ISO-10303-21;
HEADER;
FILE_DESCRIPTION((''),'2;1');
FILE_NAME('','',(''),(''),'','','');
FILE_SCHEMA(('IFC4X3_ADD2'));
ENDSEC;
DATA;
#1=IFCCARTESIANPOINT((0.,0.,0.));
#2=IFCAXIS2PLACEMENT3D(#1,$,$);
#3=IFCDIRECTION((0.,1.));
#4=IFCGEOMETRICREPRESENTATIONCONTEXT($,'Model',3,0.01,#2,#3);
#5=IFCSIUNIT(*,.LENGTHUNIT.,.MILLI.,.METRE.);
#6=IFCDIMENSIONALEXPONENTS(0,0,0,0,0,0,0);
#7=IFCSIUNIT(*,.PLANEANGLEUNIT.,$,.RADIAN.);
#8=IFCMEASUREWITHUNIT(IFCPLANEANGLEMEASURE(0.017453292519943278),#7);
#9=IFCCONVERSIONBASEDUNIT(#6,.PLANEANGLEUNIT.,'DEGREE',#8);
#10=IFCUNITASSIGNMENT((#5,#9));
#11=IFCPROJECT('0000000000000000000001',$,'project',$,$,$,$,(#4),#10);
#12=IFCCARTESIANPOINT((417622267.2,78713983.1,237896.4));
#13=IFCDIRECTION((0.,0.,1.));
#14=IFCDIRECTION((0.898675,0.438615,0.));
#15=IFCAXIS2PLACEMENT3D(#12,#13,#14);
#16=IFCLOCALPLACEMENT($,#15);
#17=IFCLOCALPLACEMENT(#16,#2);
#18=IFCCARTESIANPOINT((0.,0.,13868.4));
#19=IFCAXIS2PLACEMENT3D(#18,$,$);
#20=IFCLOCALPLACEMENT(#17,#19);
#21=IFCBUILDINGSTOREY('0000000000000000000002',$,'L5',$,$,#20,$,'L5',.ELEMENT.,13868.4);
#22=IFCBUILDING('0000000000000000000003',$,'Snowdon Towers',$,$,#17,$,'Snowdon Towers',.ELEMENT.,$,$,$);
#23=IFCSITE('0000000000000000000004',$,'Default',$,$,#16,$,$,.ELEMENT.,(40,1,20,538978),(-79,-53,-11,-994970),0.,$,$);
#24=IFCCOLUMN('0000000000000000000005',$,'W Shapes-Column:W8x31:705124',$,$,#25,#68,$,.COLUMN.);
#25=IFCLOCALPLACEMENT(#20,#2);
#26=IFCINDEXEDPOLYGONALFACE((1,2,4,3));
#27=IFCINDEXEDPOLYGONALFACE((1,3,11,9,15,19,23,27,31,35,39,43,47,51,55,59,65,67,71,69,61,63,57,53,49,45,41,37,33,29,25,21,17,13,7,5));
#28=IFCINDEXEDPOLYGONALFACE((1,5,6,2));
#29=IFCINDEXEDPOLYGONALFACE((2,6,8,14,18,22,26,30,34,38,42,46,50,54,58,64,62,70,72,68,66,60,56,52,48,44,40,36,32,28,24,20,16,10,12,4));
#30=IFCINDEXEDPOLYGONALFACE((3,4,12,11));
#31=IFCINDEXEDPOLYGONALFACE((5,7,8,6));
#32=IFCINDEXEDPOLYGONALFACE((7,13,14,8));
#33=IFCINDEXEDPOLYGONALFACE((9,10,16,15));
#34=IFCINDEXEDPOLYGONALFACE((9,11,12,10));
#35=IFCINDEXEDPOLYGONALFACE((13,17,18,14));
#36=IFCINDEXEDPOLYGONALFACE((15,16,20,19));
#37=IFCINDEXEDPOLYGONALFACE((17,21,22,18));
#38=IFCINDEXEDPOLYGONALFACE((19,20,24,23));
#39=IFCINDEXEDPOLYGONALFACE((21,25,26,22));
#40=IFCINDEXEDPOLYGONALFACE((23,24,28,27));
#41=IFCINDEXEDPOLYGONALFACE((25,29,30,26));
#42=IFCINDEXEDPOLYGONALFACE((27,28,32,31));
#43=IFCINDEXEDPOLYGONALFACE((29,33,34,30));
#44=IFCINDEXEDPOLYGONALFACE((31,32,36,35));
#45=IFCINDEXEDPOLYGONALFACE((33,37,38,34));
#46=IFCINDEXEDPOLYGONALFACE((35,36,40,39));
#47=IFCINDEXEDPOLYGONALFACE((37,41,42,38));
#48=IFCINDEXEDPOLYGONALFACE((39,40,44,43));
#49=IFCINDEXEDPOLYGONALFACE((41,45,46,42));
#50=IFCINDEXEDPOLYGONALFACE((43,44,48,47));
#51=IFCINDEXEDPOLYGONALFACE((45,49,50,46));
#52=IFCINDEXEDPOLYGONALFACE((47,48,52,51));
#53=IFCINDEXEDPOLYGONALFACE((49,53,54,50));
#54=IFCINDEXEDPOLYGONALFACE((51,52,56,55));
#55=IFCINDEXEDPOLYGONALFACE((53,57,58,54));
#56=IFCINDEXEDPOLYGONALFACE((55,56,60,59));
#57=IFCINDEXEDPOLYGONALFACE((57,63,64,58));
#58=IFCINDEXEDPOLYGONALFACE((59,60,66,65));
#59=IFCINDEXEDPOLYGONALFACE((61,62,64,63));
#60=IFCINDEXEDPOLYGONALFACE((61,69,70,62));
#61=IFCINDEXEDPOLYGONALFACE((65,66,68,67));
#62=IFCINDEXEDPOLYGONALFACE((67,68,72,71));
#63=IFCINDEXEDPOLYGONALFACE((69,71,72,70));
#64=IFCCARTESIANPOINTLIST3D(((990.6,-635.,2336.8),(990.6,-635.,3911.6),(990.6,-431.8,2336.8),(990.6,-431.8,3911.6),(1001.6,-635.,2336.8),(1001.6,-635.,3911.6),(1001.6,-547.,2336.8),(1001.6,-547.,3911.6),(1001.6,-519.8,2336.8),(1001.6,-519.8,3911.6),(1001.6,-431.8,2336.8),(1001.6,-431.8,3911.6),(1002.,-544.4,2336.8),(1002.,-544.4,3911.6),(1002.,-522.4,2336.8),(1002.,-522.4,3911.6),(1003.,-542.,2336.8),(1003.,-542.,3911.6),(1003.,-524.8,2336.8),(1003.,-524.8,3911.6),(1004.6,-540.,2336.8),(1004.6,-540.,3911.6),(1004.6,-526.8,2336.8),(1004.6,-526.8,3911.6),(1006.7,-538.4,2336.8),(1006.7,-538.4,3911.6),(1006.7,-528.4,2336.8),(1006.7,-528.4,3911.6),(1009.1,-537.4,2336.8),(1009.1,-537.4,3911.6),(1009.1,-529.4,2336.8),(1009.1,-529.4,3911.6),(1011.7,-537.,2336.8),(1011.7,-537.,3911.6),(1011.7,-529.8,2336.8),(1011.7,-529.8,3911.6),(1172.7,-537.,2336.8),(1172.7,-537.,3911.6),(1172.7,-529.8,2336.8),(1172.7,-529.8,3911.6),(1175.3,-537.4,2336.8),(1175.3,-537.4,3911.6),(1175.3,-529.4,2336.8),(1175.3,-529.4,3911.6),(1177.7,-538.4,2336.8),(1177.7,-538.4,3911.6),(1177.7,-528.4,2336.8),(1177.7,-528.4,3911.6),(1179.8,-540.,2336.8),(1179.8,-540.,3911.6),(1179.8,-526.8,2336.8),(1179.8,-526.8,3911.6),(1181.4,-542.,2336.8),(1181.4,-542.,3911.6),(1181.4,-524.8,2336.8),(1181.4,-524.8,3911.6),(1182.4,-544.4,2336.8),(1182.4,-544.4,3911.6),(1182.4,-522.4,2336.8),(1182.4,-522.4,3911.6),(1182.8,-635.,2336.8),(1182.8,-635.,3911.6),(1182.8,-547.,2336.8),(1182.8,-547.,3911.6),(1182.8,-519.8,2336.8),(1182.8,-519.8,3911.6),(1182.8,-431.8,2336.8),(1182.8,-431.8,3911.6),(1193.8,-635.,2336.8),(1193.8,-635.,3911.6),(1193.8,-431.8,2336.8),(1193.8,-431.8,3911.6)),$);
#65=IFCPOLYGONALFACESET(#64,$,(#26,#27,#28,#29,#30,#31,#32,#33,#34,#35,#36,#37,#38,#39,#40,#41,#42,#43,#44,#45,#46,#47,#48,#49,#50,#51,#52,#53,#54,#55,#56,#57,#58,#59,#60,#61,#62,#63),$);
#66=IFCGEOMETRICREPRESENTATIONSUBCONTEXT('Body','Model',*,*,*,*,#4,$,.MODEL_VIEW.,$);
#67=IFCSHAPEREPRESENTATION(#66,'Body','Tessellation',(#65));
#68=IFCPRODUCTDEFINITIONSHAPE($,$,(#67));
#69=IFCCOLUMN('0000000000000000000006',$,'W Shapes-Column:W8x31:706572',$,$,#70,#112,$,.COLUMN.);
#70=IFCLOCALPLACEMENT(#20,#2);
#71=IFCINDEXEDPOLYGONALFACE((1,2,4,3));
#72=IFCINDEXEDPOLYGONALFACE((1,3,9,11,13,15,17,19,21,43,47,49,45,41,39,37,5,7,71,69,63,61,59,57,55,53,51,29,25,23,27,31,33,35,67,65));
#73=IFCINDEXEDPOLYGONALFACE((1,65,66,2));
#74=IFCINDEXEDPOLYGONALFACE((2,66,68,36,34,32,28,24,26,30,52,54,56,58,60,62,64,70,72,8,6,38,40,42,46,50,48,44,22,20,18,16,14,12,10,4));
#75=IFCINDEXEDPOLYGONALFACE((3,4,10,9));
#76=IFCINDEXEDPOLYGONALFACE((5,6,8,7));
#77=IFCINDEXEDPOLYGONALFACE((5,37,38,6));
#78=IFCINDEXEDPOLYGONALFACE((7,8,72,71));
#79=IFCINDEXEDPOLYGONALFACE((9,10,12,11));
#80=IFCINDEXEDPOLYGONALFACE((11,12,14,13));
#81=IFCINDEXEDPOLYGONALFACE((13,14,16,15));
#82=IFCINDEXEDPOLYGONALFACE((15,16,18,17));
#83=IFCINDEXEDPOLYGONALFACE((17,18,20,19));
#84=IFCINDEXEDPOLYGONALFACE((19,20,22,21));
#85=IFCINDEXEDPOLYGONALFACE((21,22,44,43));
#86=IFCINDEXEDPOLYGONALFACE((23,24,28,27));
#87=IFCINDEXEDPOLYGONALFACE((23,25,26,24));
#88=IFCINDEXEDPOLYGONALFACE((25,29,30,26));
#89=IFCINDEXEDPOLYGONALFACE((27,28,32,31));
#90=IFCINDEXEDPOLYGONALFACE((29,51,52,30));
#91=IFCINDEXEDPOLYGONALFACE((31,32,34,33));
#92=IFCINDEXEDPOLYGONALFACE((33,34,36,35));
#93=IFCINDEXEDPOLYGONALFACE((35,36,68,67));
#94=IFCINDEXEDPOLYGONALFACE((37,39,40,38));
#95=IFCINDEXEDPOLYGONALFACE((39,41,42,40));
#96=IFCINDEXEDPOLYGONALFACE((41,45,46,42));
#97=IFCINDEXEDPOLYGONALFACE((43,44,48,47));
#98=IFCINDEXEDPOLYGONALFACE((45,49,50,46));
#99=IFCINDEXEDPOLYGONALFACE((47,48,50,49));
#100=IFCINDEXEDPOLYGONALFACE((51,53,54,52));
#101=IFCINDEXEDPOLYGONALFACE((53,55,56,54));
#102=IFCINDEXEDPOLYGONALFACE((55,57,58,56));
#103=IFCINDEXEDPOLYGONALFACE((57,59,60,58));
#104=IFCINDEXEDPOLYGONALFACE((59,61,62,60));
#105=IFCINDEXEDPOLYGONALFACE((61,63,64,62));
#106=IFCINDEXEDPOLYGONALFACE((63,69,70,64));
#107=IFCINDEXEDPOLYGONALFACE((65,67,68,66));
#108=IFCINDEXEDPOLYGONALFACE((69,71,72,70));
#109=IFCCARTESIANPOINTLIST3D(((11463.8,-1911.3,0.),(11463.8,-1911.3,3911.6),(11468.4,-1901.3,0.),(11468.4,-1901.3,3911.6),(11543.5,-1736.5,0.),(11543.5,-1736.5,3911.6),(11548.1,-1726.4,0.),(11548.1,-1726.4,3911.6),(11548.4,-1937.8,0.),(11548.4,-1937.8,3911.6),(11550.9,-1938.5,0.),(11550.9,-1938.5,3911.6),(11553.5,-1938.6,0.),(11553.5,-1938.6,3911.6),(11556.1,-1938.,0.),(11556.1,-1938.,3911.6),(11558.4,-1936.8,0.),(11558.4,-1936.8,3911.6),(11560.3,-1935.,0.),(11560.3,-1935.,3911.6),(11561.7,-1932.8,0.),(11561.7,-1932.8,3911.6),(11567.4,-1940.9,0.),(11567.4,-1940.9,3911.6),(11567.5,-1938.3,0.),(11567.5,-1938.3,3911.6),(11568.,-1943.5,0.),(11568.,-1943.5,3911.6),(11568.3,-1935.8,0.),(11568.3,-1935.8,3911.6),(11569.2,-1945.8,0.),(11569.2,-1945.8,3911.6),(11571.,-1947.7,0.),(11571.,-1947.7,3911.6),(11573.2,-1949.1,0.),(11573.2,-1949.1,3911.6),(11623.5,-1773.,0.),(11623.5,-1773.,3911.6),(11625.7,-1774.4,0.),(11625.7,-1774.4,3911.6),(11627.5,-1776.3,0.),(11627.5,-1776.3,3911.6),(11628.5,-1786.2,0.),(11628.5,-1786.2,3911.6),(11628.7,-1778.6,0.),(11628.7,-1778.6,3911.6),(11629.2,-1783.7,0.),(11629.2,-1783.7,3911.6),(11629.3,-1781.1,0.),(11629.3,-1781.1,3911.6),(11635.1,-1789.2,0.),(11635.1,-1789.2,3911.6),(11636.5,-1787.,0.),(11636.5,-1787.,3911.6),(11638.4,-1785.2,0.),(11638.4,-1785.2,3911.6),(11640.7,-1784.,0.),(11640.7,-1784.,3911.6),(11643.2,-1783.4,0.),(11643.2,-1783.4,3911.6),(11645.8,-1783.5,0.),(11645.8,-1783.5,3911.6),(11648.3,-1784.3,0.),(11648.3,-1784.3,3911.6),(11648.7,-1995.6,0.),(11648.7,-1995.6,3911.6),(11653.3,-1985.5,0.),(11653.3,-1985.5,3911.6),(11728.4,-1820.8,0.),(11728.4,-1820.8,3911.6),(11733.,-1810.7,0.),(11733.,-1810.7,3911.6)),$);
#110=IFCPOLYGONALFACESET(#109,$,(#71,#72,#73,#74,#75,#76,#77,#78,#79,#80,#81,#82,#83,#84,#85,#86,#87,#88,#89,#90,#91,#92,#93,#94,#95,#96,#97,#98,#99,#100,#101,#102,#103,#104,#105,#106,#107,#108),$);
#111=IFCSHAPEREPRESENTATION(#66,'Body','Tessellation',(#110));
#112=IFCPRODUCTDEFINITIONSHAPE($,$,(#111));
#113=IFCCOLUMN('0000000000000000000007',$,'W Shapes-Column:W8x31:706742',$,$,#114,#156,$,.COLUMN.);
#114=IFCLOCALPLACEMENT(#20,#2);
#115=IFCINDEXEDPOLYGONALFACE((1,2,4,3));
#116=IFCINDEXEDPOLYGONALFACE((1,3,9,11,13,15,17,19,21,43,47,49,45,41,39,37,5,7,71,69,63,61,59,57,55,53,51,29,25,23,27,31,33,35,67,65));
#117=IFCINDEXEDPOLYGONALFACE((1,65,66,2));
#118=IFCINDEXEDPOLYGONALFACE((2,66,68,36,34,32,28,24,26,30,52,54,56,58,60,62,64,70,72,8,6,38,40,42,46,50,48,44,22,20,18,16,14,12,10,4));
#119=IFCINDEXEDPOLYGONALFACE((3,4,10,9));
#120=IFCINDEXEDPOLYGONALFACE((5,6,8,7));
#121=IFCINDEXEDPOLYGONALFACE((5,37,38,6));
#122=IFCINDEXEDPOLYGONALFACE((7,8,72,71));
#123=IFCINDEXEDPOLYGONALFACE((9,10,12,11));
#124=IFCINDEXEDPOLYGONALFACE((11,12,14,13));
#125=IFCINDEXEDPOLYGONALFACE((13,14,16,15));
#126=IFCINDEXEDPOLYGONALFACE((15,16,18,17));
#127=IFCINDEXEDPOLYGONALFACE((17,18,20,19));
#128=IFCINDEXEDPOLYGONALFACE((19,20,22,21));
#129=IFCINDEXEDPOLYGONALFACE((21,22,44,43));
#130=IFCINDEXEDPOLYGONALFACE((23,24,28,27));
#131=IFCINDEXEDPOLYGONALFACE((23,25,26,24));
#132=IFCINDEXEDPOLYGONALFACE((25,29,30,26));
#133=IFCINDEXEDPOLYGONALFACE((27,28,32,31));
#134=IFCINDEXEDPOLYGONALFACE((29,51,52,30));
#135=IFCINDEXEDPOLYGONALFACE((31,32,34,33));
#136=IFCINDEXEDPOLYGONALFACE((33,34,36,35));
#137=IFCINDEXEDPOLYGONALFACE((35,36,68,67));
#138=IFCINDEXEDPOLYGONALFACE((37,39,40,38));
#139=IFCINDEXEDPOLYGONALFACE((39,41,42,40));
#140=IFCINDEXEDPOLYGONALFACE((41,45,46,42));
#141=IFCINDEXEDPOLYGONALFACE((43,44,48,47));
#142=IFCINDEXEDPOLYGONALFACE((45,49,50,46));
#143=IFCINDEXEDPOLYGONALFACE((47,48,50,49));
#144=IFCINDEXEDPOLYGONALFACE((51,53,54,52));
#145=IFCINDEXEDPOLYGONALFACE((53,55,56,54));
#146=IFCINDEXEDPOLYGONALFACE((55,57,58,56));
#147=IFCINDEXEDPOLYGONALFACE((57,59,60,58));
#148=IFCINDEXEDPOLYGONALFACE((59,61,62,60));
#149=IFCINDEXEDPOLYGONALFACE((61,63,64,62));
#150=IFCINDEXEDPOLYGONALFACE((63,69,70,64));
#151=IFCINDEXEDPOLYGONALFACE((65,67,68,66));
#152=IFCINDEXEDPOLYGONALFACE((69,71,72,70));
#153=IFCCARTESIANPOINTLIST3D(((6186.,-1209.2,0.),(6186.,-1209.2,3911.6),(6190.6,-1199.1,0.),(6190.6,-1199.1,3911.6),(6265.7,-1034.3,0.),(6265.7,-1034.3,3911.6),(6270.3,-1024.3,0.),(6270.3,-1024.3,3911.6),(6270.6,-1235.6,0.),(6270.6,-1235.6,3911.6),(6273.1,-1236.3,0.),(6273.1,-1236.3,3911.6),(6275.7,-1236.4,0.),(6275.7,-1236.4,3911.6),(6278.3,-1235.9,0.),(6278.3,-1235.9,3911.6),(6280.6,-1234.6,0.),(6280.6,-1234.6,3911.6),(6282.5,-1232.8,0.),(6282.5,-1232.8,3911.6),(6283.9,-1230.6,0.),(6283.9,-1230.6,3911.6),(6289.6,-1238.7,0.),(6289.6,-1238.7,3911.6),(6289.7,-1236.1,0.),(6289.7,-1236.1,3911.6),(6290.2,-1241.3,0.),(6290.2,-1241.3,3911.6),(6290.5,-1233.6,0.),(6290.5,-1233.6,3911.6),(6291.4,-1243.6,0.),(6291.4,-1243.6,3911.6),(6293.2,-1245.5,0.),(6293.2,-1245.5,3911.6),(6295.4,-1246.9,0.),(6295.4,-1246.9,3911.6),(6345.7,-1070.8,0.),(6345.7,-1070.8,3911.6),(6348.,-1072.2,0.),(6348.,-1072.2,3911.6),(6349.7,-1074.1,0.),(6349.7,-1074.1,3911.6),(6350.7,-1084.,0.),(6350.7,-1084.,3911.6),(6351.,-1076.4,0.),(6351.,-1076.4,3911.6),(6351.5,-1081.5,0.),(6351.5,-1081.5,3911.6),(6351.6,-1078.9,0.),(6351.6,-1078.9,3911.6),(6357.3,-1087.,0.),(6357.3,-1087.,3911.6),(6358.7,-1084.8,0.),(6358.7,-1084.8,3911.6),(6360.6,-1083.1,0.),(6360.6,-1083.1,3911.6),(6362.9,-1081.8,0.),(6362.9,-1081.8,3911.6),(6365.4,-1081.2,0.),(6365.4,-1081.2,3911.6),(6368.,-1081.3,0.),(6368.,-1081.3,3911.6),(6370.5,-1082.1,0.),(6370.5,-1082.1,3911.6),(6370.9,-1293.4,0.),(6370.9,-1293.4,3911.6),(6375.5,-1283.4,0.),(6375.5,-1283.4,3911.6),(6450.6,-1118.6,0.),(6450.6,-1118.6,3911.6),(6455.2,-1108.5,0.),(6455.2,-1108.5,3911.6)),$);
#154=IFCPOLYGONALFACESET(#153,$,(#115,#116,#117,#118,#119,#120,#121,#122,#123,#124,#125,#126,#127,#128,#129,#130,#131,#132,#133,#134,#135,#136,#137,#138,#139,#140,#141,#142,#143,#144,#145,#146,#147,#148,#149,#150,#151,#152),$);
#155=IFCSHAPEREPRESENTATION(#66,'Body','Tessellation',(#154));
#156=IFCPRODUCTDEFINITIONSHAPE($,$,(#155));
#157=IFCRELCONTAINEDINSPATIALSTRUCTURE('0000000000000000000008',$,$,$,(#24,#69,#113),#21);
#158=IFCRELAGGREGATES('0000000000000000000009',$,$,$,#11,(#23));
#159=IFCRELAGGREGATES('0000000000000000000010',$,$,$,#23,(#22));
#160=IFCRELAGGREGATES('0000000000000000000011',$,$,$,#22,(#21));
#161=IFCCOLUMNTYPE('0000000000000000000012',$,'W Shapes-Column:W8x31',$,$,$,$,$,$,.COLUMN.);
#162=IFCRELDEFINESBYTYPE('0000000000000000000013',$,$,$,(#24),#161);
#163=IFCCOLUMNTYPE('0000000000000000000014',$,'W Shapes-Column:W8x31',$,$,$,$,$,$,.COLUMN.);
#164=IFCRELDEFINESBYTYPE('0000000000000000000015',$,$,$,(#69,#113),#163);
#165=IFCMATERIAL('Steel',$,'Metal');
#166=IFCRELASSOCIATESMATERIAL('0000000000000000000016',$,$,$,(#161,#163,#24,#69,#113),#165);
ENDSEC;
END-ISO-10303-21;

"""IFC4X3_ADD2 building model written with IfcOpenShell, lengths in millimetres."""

from ifc_helpers import new_model, entity, si_unit, converted_unit, direction, frame, frame_2d, origin, place, context, subcontext, project, spatial, i_section, extrude, source, transform, mapped, material, material_profile, profile_set, profile_usage, type_object, type_shapes, element, save


model = new_model("IFC4X3_ADD2")

# Units and contexts
model_context = context("Model", 3, precision=0.01, world=origin(), true_north=direction((0.0, 1.0)))
body_context = subcontext(model_context, "Body", "Model", "MODEL_VIEW")
ifc_project = project(units=[si_unit("LENGTHUNIT", "METRE", prefix="MILLI"), converted_unit("PLANEANGLEUNIT", "DEGREE", entity("IfcPlaneAngleMeasure", 0.017453292519943278), si_unit("PLANEANGLEUNIT", "RADIAN"), dimensions=[0, 0, 0, 0, 0, 0, 0])], contexts=[model_context])

# Site, building, storey
site_placement = place(None, frame((417622267.2, 78713983.1, 237896.4), z_axis=(0.0, 0.0, 1.0), x_axis=(0.898675, 0.438615, 0.0)))
site = spatial("IfcSite", under=ifc_project, at=site_placement, Name="Default", CompositionType="ELEMENT", RefLatitude=(40, 1, 20, 538978), RefLongitude=(-79, -53, -11, -994970), RefElevation=0.0)
building_placement = place(site_placement, origin())
building = spatial("IfcBuilding", under=site, at=building_placement, Name="Snowdon Towers", LongName="Snowdon Towers", CompositionType="ELEMENT")
storey_placement = place(building_placement, frame((0.0, 0.0, 13868.4)))
storey = spatial("IfcBuildingStorey", under=building, at=storey_placement, Name="L5", LongName="L5", CompositionType="ELEMENT", Elevation=13868.4)

# Columns
ifc_material_1 = material(Name="Steel", Category="Metal")
ifc_material_profile_1 = material_profile(ifc_material_1, i_section(OverallWidth=203.2, OverallDepth=203.2, WebThickness=7.2, FlangeThickness=11.0, FilletRadius=10.0, at=frame_2d((0.0, 0.0), x_axis=(1.0, 0.0))), Name="W8x31")
ifc_profile_set_1 = profile_set([ifc_material_profile_1], Name="W8x31")
ifc_profile_usage_1 = profile_usage(ifc_profile_set_1)
column_type_1 = type_object("IfcColumnType", Name="W Shapes-Column:W8x31", PredefinedType="COLUMN", material=ifc_profile_set_1)
shared_shape_1 = source(origin(), body_context, "Body", "SweptSolid", [
    extrude(i_section(OverallWidth=203.2, OverallDepth=203.2, WebThickness=7.2, FlangeThickness=11.0, FilletRadius=10.0, at=frame_2d((0.0, 0.0), x_axis=(1.0, 0.0))), frame((0.0, 0.0, 16205.2), z_axis=(0.0, 0.0, 1.0), x_axis=(-1.0, 0.0, 0.0)), (0.0, 0.0, 1.0), 1574.8),
])
type_shapes(column_type_1, [shared_shape_1])
column_1_placement = place(storey_placement, frame((1092.2, -533.4, -13868.4), z_axis=(0.0, 0.0, 1.0), x_axis=(0.0, 1.0, 0.0)))
element("IfcColumn", 1, at=column_1_placement, inside=storey, type_object=column_type_1, material=ifc_profile_usage_1, Name="W Shapes-Column:W8x31:705124", PredefinedType="COLUMN", context=body_context, shape_type="MappedRepresentation", body=[
    mapped(shared_shape_1, transform((0.0, 0.0, 0.0), scale=1.0)),
])
column_type_2 = type_object("IfcColumnType", Name="W Shapes-Column:W8x31", PredefinedType="COLUMN", material=ifc_profile_set_1)
shared_shape_2 = source(origin(), body_context, "Body", "SweptSolid", [
    extrude(i_section(OverallWidth=203.2, OverallDepth=203.2, WebThickness=7.2, FlangeThickness=11.0, FilletRadius=10.0, at=frame_2d((0.0, 0.0), x_axis=(1.0, 0.0))), frame((0.0, 0.0, 13868.4), z_axis=(0.0, 0.0, 1.0), x_axis=(-1.0, 0.0, 0.0)), (0.0, 0.0, 1.0), 3911.6),
])
type_shapes(column_type_2, [shared_shape_2])
for number, where, z_axis, x_axis, name in (
    (2, (11598.4, -1861.0, -13868.4), (0.0, 0.0, 1.0), (0.909961, -0.414693, 0.0), "W Shapes-Column:W8x31:706572"),
    (3, (6320.6, -1158.8, -13868.4), (0.0, 0.0, 1.0), (0.909961, -0.414693, 0.0), "W Shapes-Column:W8x31:706742"),
):
    element("IfcColumn", number, at=place(storey_placement, frame(where, z_axis=z_axis, x_axis=x_axis)), inside=storey, type_object=column_type_2, material=ifc_profile_usage_1, Name=name, PredefinedType="COLUMN", context=body_context, shape_type="MappedRepresentation", body=[
        mapped(shared_shape_2, transform((0.0, 0.0, 0.0), scale=1.0)),
    ])

save(model, "model.ifc")
